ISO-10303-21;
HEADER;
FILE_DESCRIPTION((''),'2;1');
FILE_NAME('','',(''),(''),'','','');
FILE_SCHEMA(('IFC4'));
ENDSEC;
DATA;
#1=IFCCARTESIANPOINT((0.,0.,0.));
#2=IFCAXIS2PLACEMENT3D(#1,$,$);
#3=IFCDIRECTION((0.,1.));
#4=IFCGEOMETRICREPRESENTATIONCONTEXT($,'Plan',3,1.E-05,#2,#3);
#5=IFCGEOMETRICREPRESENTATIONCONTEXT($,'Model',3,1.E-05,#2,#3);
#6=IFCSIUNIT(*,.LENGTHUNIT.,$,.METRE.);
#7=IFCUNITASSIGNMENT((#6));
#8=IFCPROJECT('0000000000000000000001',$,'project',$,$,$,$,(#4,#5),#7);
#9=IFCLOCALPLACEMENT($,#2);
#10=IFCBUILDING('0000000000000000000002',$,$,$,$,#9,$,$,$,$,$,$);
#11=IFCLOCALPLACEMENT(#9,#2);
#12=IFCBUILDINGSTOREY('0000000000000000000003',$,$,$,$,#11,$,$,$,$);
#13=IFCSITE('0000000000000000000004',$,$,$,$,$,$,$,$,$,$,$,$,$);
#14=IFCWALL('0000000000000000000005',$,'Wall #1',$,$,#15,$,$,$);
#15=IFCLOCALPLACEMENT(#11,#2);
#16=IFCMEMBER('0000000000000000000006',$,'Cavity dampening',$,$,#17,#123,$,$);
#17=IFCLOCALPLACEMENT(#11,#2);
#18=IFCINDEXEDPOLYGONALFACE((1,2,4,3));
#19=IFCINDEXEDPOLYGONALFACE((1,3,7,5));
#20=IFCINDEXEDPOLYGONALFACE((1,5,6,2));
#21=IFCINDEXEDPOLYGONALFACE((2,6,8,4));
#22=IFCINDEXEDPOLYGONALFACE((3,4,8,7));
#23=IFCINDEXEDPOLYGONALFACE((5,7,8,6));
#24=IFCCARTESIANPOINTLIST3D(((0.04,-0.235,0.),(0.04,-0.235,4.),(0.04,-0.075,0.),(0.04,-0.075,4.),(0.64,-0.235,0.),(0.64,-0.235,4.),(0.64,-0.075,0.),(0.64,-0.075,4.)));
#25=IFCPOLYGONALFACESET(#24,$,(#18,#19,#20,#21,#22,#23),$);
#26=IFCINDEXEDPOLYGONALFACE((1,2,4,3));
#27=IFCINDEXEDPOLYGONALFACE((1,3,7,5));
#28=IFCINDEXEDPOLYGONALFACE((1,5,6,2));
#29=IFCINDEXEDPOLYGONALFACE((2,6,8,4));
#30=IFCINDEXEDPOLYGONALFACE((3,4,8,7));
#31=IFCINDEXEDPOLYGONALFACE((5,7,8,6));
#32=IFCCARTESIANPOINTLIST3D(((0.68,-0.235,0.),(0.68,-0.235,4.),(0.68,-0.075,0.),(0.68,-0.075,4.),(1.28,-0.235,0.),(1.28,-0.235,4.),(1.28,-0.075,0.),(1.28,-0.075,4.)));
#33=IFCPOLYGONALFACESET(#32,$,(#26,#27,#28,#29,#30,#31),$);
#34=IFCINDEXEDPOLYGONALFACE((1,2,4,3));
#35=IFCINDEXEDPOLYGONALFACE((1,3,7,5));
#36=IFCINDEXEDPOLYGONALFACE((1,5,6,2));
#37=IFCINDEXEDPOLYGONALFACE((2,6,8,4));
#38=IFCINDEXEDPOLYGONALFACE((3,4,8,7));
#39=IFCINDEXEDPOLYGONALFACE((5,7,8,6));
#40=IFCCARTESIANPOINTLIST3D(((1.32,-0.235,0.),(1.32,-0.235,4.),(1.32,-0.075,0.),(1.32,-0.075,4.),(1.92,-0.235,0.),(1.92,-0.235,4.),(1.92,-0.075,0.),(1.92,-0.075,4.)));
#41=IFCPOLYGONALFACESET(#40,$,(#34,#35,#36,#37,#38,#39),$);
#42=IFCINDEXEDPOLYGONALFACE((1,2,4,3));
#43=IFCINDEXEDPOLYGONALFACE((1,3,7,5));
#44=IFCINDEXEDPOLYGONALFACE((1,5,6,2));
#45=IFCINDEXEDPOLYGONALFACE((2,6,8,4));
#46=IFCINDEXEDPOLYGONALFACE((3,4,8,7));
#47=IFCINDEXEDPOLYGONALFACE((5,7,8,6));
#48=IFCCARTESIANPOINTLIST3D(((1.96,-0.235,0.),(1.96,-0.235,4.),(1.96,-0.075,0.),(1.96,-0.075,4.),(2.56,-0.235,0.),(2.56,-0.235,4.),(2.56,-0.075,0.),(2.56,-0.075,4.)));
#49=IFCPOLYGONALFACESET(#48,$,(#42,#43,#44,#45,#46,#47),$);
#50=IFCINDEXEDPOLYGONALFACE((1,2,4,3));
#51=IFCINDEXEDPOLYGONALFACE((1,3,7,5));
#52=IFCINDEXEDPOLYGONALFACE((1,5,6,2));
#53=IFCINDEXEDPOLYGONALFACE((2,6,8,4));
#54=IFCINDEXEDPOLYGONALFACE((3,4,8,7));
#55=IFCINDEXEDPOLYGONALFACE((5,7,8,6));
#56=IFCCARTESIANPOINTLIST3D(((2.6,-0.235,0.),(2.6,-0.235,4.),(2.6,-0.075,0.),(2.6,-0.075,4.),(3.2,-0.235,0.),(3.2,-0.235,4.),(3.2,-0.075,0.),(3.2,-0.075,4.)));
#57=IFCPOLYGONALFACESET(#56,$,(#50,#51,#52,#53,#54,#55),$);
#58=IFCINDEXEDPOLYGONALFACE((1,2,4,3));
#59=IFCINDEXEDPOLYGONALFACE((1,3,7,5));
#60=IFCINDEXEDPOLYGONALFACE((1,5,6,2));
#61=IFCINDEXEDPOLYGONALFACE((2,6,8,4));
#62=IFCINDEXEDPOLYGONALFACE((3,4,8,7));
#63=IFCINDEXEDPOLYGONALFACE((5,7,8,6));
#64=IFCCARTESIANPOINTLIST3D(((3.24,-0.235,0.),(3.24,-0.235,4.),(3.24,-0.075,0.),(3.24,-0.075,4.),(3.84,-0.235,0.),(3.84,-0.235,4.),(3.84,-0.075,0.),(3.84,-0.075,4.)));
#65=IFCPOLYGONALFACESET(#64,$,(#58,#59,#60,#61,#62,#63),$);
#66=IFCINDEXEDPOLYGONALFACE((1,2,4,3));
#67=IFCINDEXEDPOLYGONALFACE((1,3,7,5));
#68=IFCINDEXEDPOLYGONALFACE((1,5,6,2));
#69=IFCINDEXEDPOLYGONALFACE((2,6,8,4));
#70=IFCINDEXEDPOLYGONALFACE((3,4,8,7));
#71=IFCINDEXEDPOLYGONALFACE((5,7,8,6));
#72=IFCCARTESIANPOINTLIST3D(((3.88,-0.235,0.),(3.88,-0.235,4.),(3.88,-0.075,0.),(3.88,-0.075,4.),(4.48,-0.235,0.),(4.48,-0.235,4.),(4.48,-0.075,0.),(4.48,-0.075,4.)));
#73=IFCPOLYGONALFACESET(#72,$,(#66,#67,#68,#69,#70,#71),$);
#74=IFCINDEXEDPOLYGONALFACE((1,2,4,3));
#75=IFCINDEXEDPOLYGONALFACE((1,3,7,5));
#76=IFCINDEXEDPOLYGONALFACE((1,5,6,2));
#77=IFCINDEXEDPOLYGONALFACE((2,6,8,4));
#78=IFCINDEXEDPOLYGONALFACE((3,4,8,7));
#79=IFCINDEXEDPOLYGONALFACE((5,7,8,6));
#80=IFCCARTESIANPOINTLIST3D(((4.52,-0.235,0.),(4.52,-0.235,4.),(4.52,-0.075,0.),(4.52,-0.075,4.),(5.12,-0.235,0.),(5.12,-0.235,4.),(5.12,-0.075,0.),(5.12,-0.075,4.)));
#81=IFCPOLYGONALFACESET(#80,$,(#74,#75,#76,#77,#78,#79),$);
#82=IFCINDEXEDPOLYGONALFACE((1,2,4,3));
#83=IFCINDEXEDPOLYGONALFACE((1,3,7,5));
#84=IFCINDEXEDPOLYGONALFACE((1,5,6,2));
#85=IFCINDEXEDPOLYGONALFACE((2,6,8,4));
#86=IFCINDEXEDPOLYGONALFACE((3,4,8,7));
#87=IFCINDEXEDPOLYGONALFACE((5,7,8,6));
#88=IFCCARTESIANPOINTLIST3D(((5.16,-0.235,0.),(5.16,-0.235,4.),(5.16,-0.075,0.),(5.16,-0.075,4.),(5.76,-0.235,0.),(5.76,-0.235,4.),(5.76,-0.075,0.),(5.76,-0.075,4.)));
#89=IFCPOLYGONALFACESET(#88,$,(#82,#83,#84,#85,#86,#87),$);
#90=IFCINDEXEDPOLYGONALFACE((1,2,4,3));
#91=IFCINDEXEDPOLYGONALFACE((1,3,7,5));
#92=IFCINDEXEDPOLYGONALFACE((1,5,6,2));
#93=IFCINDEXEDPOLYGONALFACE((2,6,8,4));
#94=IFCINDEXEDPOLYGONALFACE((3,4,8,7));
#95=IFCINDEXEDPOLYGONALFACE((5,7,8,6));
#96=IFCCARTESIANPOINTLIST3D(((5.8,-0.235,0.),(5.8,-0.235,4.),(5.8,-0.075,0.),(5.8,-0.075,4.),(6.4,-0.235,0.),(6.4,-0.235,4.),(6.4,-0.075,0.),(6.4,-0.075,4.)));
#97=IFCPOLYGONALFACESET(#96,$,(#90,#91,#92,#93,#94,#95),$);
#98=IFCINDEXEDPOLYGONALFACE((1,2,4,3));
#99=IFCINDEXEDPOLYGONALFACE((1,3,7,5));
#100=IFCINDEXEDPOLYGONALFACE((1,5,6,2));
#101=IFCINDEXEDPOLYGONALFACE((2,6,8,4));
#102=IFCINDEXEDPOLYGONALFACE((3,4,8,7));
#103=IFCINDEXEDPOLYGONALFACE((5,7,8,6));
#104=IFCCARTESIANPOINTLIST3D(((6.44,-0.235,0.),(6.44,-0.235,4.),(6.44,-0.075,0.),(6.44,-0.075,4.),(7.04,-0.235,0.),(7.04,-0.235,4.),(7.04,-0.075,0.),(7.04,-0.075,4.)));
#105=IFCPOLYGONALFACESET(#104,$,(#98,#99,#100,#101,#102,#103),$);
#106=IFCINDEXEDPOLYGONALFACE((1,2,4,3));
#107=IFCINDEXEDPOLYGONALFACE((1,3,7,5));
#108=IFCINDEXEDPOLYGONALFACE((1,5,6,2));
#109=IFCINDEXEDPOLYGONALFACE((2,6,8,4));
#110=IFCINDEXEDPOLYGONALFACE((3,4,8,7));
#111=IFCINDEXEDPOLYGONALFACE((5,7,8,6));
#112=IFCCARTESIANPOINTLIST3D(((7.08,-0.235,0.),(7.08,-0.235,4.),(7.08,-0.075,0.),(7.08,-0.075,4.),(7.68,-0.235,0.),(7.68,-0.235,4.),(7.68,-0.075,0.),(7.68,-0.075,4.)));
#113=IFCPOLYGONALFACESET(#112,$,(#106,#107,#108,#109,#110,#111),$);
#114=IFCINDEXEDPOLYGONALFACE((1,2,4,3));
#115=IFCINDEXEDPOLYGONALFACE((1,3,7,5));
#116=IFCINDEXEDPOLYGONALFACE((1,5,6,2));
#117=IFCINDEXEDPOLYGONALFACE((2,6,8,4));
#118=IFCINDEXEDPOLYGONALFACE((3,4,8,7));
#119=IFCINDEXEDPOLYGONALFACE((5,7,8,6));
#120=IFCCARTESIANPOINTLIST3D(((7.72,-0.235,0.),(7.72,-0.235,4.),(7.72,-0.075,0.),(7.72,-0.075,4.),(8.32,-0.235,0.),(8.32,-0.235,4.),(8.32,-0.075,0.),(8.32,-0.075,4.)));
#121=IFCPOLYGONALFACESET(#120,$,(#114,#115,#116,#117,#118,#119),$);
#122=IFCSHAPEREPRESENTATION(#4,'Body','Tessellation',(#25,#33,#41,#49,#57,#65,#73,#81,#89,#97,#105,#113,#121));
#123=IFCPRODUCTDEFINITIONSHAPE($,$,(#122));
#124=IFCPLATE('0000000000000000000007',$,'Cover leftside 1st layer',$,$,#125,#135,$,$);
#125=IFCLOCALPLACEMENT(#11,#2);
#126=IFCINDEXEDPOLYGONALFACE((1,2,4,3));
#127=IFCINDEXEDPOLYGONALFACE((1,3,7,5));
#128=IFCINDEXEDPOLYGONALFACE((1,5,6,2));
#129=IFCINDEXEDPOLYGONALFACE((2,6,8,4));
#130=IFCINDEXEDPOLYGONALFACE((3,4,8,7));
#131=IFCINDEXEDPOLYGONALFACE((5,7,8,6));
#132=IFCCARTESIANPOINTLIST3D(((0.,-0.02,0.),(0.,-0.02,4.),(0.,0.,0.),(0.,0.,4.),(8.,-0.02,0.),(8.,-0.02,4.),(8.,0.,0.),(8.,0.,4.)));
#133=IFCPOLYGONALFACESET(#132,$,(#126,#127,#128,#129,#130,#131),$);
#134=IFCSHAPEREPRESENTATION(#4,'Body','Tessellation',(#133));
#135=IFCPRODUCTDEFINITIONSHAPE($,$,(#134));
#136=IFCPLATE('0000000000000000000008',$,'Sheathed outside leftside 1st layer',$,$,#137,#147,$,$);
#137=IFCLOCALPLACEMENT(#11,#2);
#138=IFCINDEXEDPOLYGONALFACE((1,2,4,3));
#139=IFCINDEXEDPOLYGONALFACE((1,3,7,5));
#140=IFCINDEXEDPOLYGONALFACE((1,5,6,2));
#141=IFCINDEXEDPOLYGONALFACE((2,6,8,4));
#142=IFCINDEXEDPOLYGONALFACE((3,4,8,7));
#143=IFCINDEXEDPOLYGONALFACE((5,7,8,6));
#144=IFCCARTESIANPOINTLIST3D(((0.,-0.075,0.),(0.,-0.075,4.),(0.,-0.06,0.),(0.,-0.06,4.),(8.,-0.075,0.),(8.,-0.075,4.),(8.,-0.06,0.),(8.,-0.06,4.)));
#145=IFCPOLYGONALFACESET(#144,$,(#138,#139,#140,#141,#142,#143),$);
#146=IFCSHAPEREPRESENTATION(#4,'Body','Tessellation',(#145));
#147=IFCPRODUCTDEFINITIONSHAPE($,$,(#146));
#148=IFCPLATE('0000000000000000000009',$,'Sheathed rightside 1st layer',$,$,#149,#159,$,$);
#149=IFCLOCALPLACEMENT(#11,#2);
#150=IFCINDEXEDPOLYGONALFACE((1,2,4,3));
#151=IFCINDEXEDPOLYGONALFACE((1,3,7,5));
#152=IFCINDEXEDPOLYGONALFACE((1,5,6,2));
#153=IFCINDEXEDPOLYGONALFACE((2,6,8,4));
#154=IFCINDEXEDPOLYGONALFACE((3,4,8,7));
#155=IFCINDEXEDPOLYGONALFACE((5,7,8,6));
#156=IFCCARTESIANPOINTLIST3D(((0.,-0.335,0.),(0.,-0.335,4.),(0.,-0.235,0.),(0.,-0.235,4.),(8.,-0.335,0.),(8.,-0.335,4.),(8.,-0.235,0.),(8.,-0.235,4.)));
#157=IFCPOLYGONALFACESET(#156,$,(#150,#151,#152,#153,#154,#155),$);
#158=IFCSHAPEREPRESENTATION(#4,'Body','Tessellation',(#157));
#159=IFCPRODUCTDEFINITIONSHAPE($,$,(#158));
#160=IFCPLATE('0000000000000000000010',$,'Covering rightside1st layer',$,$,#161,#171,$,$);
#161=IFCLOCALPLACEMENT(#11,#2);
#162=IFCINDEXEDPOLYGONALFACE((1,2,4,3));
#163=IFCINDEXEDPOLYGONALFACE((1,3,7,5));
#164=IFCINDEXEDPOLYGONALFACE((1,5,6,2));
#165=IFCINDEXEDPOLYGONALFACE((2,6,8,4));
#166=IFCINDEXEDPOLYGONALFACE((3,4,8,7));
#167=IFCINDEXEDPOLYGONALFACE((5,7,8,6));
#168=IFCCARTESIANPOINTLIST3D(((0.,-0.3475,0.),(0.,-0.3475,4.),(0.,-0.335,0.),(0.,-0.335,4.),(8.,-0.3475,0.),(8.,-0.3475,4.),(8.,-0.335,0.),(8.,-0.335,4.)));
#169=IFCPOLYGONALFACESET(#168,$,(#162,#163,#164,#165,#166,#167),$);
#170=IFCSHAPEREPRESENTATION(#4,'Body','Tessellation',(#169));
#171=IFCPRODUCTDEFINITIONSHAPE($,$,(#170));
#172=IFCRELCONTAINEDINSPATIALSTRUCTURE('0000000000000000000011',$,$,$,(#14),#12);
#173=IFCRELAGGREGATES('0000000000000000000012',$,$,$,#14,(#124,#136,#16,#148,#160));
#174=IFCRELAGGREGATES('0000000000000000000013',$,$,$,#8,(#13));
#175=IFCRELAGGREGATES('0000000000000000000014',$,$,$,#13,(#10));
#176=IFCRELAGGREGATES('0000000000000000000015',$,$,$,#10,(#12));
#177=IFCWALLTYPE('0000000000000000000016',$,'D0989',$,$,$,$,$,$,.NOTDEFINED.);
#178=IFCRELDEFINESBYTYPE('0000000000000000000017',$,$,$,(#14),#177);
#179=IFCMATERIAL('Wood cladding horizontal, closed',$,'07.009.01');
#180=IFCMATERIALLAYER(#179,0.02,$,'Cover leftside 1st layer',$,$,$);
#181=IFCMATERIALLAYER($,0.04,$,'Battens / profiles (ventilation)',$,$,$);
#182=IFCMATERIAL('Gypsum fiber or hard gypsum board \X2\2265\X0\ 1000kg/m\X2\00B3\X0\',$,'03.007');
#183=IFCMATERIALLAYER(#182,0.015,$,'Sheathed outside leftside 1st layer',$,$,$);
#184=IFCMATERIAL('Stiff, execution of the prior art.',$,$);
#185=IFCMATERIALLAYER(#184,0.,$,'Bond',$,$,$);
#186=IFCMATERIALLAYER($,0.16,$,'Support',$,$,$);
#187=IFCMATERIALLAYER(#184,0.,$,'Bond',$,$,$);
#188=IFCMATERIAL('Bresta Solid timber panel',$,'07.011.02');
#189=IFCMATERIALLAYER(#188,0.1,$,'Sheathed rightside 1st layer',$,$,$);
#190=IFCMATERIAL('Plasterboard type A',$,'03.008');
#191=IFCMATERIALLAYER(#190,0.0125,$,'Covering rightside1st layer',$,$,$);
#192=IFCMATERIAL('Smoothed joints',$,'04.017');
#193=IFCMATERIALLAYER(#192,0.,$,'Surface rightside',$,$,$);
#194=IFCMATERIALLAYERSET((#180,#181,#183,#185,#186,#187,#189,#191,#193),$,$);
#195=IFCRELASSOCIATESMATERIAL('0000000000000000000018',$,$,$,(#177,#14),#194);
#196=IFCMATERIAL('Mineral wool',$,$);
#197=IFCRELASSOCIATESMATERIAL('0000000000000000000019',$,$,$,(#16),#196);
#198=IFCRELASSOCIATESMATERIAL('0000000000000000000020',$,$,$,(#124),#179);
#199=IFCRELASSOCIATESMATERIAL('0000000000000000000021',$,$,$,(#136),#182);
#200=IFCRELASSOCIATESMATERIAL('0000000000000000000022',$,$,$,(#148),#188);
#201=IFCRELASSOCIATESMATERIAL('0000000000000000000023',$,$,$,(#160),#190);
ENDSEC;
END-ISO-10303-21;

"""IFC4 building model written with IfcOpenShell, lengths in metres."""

from ifc_helpers import new_model, si_unit, direction, frame, frame_2d, origin, origin_with_axes, place, context, project, spatial, rectangle, extrude, material, layer, layer_set, type_object, element, aggregate, save


model = new_model("IFC4")

# Units and contexts
plan_context = context("Plan", 3, precision=1e-05, world=origin(), true_north=direction((0.0, 1.0)))
model_context = context("Model", 3, precision=1e-05, world=origin(), true_north=direction((0.0, 1.0)))
ifc_project = project(units=[si_unit("LENGTHUNIT", "METRE")], contexts=[plan_context, model_context])

# Site, building, storey
site = spatial("IfcSite", under=ifc_project)
building_placement = place(None, origin())
building = spatial("IfcBuilding", under=site, at=building_placement)
storey_placement = place(building_placement, origin())
storey = spatial("IfcBuildingStorey", under=building, at=storey_placement)

# Wall, member, plates
ifc_material_1 = material(Name="Wood cladding horizontal, closed", Category="07.009.01")
ifc_layer_1 = layer(ifc_material_1, 0.02, Name="Cover leftside 1st layer")
ifc_layer_2 = layer(None, 0.04, Name="Battens / profiles (ventilation)")
ifc_material_2 = material(Name="Gypsum fiber or hard gypsum board ≥ 1000kg/m³", Category="03.007")
ifc_layer_3 = layer(ifc_material_2, 0.015, Name="Sheathed outside leftside 1st layer")
ifc_material_3 = material(Name="Stiff, execution of the prior art.")
ifc_layer_4 = layer(ifc_material_3, 0.0, Name="Bond")
ifc_layer_5 = layer(None, 0.16, Name="Support")
ifc_layer_6 = layer(ifc_material_3, 0.0, Name="Bond")
ifc_material_4 = material(Name="Bresta Solid timber panel", Category="07.011.02")
ifc_layer_7 = layer(ifc_material_4, 0.1, Name="Sheathed rightside 1st layer")
ifc_material_5 = material(Name="Plasterboard type A", Category="03.008")
ifc_layer_8 = layer(ifc_material_5, 0.0125, Name="Covering rightside1st layer")
ifc_material_6 = material(Name="Smoothed joints", Category="04.017")
ifc_layer_9 = layer(ifc_material_6, 0.0, Name="Surface rightside")
ifc_layer_set = layer_set([ifc_layer_1, ifc_layer_2, ifc_layer_3, ifc_layer_4, ifc_layer_5, ifc_layer_6, ifc_layer_7, ifc_layer_8, ifc_layer_9])
wall_type = type_object("IfcWallType", Name="D0989", PredefinedType="NOTDEFINED", material=ifc_layer_set)
wall_placement = place(None, frame((0.0, 0.0, 0.0), z_axis=(0.0, -1.0, 0.0), x_axis=(1.0, 0.0, 0.0)))
wall = element("IfcWall", 1, at=wall_placement, inside=storey, type_object=wall_type, material=ifc_layer_set, Name="Wall #1")
ifc_material_7 = material(Name="Mineral wool")
member_1_placement = place(wall_placement, origin())
member_1 = element("IfcMember", 2, at=member_1_placement, material=ifc_material_7, Name="Cavity dampening", context=plan_context, shape_type="SweptSolid", body=[
    extrude(rectangle(XDim=0.6, YDim=0.16, at=frame_2d((0.3, 0.08), x_axis=(1.0, 0.0))), frame((0.04, 4.0, 0.075), z_axis=(0.0, -1.0, 0.0), x_axis=(1.0, 0.0, 0.0)), (0.0, 0.0, 1.0), 4.0),
    extrude(rectangle(XDim=0.6, YDim=0.16, at=frame_2d((0.3, 0.08), x_axis=(1.0, 0.0))), frame((0.68, 4.0, 0.075), z_axis=(0.0, -1.0, 0.0), x_axis=(1.0, 0.0, 0.0)), (0.0, 0.0, 1.0), 4.0),
    extrude(rectangle(XDim=0.6, YDim=0.16, at=frame_2d((0.3, 0.08), x_axis=(1.0, 0.0))), frame((1.32, 4.0, 0.075), z_axis=(0.0, -1.0, 0.0), x_axis=(1.0, 0.0, 0.0)), (0.0, 0.0, 1.0), 4.0),
    extrude(rectangle(XDim=0.6, YDim=0.16, at=frame_2d((0.3, 0.08), x_axis=(1.0, 0.0))), frame((1.96, 4.0, 0.075), z_axis=(0.0, -1.0, 0.0), x_axis=(1.0, 0.0, 0.0)), (0.0, 0.0, 1.0), 4.0),
    extrude(rectangle(XDim=0.6, YDim=0.16, at=frame_2d((0.3, 0.08), x_axis=(1.0, 0.0))), frame((2.6, 4.0, 0.075), z_axis=(0.0, -1.0, 0.0), x_axis=(1.0, 0.0, 0.0)), (0.0, 0.0, 1.0), 4.0),
    extrude(rectangle(XDim=0.6, YDim=0.16, at=frame_2d((0.3, 0.08), x_axis=(1.0, 0.0))), frame((3.24, 4.0, 0.075), z_axis=(0.0, -1.0, 0.0), x_axis=(1.0, 0.0, 0.0)), (0.0, 0.0, 1.0), 4.0),
    extrude(rectangle(XDim=0.6, YDim=0.16, at=frame_2d((0.3, 0.08), x_axis=(1.0, 0.0))), frame((3.88, 4.0, 0.075), z_axis=(0.0, -1.0, 0.0), x_axis=(1.0, 0.0, 0.0)), (0.0, 0.0, 1.0), 4.0),
    extrude(rectangle(XDim=0.6, YDim=0.16, at=frame_2d((0.3, 0.08), x_axis=(1.0, 0.0))), frame((4.52, 4.0, 0.075), z_axis=(0.0, -1.0, 0.0), x_axis=(1.0, 0.0, 0.0)), (0.0, 0.0, 1.0), 4.0),
    extrude(rectangle(XDim=0.6, YDim=0.16, at=frame_2d((0.3, 0.08), x_axis=(1.0, 0.0))), frame((5.16, 4.0, 0.075), z_axis=(0.0, -1.0, 0.0), x_axis=(1.0, 0.0, 0.0)), (0.0, 0.0, 1.0), 4.0),
    extrude(rectangle(XDim=0.6, YDim=0.16, at=frame_2d((0.3, 0.08), x_axis=(1.0, 0.0))), frame((5.8, 4.0, 0.075), z_axis=(0.0, -1.0, 0.0), x_axis=(1.0, 0.0, 0.0)), (0.0, 0.0, 1.0), 4.0),
    extrude(rectangle(XDim=0.6, YDim=0.16, at=frame_2d((0.3, 0.08), x_axis=(1.0, 0.0))), frame((6.44, 4.0, 0.075), z_axis=(0.0, -1.0, 0.0), x_axis=(1.0, 0.0, 0.0)), (0.0, 0.0, 1.0), 4.0),
    extrude(rectangle(XDim=0.6, YDim=0.16, at=frame_2d((0.3, 0.08), x_axis=(1.0, 0.0))), frame((7.08, 4.0, 0.075), z_axis=(0.0, -1.0, 0.0), x_axis=(1.0, 0.0, 0.0)), (0.0, 0.0, 1.0), 4.0),
    extrude(rectangle(XDim=0.6, YDim=0.16, at=frame_2d((0.3, 0.08), x_axis=(1.0, 0.0))), frame((7.72, 4.0, 0.075), z_axis=(0.0, -1.0, 0.0), x_axis=(1.0, 0.0, 0.0)), (0.0, 0.0, 1.0), 4.0),
])
plate_1_placement = place(wall_placement, origin())
plate_1 = element("IfcPlate", 3, at=plate_1_placement, material=ifc_material_1, Name="Cover leftside 1st layer", context=plan_context, shape_type="SweptSolid", body=[
    extrude(rectangle(XDim=8.0, YDim=4.0, at=frame_2d((4.0, 2.0), x_axis=(1.0, 0.0))), origin_with_axes(), (0.0, 0.0, 1.0), 0.02),
])
plate_2_placement = place(wall_placement, origin())
plate_2 = element("IfcPlate", 4, at=plate_2_placement, material=ifc_material_2, Name="Sheathed outside leftside 1st layer", context=plan_context, shape_type="SweptSolid", body=[
    extrude(rectangle(XDim=8.0, YDim=4.0, at=frame_2d((4.0, 2.0), x_axis=(1.0, 0.0))), frame((0.0, 0.0, 0.06), z_axis=(0.0, 0.0, 1.0), x_axis=(1.0, 0.0, 0.0)), (0.0, 0.0, 1.0), 0.015),
])
plate_3_placement = place(wall_placement, origin())
plate_3 = element("IfcPlate", 5, at=plate_3_placement, material=ifc_material_4, Name="Sheathed rightside 1st layer", context=plan_context, shape_type="SweptSolid", body=[
    extrude(rectangle(XDim=8.0, YDim=4.0, at=frame_2d((4.0, 2.0), x_axis=(1.0, 0.0))), frame((0.0, 0.0, 0.235), z_axis=(0.0, 0.0, 1.0), x_axis=(1.0, 0.0, 0.0)), (0.0, 0.0, 1.0), 0.1),
])
plate_4_placement = place(wall_placement, origin())
plate_4 = element("IfcPlate", 6, at=plate_4_placement, material=ifc_material_5, Name="Covering rightside1st layer", context=plan_context, shape_type="SweptSolid", body=[
    extrude(rectangle(XDim=8.0, YDim=4.0, at=frame_2d((4.0, 2.0), x_axis=(1.0, 0.0))), frame((0.0, 0.0, 0.335), z_axis=(0.0, 0.0, 1.0), x_axis=(1.0, 0.0, 0.0)), (0.0, 0.0, 1.0), 0.0125),
])
aggregate(wall, [plate_1, plate_2, member_1, plate_3, plate_4])

save(model, "model.ifc")
